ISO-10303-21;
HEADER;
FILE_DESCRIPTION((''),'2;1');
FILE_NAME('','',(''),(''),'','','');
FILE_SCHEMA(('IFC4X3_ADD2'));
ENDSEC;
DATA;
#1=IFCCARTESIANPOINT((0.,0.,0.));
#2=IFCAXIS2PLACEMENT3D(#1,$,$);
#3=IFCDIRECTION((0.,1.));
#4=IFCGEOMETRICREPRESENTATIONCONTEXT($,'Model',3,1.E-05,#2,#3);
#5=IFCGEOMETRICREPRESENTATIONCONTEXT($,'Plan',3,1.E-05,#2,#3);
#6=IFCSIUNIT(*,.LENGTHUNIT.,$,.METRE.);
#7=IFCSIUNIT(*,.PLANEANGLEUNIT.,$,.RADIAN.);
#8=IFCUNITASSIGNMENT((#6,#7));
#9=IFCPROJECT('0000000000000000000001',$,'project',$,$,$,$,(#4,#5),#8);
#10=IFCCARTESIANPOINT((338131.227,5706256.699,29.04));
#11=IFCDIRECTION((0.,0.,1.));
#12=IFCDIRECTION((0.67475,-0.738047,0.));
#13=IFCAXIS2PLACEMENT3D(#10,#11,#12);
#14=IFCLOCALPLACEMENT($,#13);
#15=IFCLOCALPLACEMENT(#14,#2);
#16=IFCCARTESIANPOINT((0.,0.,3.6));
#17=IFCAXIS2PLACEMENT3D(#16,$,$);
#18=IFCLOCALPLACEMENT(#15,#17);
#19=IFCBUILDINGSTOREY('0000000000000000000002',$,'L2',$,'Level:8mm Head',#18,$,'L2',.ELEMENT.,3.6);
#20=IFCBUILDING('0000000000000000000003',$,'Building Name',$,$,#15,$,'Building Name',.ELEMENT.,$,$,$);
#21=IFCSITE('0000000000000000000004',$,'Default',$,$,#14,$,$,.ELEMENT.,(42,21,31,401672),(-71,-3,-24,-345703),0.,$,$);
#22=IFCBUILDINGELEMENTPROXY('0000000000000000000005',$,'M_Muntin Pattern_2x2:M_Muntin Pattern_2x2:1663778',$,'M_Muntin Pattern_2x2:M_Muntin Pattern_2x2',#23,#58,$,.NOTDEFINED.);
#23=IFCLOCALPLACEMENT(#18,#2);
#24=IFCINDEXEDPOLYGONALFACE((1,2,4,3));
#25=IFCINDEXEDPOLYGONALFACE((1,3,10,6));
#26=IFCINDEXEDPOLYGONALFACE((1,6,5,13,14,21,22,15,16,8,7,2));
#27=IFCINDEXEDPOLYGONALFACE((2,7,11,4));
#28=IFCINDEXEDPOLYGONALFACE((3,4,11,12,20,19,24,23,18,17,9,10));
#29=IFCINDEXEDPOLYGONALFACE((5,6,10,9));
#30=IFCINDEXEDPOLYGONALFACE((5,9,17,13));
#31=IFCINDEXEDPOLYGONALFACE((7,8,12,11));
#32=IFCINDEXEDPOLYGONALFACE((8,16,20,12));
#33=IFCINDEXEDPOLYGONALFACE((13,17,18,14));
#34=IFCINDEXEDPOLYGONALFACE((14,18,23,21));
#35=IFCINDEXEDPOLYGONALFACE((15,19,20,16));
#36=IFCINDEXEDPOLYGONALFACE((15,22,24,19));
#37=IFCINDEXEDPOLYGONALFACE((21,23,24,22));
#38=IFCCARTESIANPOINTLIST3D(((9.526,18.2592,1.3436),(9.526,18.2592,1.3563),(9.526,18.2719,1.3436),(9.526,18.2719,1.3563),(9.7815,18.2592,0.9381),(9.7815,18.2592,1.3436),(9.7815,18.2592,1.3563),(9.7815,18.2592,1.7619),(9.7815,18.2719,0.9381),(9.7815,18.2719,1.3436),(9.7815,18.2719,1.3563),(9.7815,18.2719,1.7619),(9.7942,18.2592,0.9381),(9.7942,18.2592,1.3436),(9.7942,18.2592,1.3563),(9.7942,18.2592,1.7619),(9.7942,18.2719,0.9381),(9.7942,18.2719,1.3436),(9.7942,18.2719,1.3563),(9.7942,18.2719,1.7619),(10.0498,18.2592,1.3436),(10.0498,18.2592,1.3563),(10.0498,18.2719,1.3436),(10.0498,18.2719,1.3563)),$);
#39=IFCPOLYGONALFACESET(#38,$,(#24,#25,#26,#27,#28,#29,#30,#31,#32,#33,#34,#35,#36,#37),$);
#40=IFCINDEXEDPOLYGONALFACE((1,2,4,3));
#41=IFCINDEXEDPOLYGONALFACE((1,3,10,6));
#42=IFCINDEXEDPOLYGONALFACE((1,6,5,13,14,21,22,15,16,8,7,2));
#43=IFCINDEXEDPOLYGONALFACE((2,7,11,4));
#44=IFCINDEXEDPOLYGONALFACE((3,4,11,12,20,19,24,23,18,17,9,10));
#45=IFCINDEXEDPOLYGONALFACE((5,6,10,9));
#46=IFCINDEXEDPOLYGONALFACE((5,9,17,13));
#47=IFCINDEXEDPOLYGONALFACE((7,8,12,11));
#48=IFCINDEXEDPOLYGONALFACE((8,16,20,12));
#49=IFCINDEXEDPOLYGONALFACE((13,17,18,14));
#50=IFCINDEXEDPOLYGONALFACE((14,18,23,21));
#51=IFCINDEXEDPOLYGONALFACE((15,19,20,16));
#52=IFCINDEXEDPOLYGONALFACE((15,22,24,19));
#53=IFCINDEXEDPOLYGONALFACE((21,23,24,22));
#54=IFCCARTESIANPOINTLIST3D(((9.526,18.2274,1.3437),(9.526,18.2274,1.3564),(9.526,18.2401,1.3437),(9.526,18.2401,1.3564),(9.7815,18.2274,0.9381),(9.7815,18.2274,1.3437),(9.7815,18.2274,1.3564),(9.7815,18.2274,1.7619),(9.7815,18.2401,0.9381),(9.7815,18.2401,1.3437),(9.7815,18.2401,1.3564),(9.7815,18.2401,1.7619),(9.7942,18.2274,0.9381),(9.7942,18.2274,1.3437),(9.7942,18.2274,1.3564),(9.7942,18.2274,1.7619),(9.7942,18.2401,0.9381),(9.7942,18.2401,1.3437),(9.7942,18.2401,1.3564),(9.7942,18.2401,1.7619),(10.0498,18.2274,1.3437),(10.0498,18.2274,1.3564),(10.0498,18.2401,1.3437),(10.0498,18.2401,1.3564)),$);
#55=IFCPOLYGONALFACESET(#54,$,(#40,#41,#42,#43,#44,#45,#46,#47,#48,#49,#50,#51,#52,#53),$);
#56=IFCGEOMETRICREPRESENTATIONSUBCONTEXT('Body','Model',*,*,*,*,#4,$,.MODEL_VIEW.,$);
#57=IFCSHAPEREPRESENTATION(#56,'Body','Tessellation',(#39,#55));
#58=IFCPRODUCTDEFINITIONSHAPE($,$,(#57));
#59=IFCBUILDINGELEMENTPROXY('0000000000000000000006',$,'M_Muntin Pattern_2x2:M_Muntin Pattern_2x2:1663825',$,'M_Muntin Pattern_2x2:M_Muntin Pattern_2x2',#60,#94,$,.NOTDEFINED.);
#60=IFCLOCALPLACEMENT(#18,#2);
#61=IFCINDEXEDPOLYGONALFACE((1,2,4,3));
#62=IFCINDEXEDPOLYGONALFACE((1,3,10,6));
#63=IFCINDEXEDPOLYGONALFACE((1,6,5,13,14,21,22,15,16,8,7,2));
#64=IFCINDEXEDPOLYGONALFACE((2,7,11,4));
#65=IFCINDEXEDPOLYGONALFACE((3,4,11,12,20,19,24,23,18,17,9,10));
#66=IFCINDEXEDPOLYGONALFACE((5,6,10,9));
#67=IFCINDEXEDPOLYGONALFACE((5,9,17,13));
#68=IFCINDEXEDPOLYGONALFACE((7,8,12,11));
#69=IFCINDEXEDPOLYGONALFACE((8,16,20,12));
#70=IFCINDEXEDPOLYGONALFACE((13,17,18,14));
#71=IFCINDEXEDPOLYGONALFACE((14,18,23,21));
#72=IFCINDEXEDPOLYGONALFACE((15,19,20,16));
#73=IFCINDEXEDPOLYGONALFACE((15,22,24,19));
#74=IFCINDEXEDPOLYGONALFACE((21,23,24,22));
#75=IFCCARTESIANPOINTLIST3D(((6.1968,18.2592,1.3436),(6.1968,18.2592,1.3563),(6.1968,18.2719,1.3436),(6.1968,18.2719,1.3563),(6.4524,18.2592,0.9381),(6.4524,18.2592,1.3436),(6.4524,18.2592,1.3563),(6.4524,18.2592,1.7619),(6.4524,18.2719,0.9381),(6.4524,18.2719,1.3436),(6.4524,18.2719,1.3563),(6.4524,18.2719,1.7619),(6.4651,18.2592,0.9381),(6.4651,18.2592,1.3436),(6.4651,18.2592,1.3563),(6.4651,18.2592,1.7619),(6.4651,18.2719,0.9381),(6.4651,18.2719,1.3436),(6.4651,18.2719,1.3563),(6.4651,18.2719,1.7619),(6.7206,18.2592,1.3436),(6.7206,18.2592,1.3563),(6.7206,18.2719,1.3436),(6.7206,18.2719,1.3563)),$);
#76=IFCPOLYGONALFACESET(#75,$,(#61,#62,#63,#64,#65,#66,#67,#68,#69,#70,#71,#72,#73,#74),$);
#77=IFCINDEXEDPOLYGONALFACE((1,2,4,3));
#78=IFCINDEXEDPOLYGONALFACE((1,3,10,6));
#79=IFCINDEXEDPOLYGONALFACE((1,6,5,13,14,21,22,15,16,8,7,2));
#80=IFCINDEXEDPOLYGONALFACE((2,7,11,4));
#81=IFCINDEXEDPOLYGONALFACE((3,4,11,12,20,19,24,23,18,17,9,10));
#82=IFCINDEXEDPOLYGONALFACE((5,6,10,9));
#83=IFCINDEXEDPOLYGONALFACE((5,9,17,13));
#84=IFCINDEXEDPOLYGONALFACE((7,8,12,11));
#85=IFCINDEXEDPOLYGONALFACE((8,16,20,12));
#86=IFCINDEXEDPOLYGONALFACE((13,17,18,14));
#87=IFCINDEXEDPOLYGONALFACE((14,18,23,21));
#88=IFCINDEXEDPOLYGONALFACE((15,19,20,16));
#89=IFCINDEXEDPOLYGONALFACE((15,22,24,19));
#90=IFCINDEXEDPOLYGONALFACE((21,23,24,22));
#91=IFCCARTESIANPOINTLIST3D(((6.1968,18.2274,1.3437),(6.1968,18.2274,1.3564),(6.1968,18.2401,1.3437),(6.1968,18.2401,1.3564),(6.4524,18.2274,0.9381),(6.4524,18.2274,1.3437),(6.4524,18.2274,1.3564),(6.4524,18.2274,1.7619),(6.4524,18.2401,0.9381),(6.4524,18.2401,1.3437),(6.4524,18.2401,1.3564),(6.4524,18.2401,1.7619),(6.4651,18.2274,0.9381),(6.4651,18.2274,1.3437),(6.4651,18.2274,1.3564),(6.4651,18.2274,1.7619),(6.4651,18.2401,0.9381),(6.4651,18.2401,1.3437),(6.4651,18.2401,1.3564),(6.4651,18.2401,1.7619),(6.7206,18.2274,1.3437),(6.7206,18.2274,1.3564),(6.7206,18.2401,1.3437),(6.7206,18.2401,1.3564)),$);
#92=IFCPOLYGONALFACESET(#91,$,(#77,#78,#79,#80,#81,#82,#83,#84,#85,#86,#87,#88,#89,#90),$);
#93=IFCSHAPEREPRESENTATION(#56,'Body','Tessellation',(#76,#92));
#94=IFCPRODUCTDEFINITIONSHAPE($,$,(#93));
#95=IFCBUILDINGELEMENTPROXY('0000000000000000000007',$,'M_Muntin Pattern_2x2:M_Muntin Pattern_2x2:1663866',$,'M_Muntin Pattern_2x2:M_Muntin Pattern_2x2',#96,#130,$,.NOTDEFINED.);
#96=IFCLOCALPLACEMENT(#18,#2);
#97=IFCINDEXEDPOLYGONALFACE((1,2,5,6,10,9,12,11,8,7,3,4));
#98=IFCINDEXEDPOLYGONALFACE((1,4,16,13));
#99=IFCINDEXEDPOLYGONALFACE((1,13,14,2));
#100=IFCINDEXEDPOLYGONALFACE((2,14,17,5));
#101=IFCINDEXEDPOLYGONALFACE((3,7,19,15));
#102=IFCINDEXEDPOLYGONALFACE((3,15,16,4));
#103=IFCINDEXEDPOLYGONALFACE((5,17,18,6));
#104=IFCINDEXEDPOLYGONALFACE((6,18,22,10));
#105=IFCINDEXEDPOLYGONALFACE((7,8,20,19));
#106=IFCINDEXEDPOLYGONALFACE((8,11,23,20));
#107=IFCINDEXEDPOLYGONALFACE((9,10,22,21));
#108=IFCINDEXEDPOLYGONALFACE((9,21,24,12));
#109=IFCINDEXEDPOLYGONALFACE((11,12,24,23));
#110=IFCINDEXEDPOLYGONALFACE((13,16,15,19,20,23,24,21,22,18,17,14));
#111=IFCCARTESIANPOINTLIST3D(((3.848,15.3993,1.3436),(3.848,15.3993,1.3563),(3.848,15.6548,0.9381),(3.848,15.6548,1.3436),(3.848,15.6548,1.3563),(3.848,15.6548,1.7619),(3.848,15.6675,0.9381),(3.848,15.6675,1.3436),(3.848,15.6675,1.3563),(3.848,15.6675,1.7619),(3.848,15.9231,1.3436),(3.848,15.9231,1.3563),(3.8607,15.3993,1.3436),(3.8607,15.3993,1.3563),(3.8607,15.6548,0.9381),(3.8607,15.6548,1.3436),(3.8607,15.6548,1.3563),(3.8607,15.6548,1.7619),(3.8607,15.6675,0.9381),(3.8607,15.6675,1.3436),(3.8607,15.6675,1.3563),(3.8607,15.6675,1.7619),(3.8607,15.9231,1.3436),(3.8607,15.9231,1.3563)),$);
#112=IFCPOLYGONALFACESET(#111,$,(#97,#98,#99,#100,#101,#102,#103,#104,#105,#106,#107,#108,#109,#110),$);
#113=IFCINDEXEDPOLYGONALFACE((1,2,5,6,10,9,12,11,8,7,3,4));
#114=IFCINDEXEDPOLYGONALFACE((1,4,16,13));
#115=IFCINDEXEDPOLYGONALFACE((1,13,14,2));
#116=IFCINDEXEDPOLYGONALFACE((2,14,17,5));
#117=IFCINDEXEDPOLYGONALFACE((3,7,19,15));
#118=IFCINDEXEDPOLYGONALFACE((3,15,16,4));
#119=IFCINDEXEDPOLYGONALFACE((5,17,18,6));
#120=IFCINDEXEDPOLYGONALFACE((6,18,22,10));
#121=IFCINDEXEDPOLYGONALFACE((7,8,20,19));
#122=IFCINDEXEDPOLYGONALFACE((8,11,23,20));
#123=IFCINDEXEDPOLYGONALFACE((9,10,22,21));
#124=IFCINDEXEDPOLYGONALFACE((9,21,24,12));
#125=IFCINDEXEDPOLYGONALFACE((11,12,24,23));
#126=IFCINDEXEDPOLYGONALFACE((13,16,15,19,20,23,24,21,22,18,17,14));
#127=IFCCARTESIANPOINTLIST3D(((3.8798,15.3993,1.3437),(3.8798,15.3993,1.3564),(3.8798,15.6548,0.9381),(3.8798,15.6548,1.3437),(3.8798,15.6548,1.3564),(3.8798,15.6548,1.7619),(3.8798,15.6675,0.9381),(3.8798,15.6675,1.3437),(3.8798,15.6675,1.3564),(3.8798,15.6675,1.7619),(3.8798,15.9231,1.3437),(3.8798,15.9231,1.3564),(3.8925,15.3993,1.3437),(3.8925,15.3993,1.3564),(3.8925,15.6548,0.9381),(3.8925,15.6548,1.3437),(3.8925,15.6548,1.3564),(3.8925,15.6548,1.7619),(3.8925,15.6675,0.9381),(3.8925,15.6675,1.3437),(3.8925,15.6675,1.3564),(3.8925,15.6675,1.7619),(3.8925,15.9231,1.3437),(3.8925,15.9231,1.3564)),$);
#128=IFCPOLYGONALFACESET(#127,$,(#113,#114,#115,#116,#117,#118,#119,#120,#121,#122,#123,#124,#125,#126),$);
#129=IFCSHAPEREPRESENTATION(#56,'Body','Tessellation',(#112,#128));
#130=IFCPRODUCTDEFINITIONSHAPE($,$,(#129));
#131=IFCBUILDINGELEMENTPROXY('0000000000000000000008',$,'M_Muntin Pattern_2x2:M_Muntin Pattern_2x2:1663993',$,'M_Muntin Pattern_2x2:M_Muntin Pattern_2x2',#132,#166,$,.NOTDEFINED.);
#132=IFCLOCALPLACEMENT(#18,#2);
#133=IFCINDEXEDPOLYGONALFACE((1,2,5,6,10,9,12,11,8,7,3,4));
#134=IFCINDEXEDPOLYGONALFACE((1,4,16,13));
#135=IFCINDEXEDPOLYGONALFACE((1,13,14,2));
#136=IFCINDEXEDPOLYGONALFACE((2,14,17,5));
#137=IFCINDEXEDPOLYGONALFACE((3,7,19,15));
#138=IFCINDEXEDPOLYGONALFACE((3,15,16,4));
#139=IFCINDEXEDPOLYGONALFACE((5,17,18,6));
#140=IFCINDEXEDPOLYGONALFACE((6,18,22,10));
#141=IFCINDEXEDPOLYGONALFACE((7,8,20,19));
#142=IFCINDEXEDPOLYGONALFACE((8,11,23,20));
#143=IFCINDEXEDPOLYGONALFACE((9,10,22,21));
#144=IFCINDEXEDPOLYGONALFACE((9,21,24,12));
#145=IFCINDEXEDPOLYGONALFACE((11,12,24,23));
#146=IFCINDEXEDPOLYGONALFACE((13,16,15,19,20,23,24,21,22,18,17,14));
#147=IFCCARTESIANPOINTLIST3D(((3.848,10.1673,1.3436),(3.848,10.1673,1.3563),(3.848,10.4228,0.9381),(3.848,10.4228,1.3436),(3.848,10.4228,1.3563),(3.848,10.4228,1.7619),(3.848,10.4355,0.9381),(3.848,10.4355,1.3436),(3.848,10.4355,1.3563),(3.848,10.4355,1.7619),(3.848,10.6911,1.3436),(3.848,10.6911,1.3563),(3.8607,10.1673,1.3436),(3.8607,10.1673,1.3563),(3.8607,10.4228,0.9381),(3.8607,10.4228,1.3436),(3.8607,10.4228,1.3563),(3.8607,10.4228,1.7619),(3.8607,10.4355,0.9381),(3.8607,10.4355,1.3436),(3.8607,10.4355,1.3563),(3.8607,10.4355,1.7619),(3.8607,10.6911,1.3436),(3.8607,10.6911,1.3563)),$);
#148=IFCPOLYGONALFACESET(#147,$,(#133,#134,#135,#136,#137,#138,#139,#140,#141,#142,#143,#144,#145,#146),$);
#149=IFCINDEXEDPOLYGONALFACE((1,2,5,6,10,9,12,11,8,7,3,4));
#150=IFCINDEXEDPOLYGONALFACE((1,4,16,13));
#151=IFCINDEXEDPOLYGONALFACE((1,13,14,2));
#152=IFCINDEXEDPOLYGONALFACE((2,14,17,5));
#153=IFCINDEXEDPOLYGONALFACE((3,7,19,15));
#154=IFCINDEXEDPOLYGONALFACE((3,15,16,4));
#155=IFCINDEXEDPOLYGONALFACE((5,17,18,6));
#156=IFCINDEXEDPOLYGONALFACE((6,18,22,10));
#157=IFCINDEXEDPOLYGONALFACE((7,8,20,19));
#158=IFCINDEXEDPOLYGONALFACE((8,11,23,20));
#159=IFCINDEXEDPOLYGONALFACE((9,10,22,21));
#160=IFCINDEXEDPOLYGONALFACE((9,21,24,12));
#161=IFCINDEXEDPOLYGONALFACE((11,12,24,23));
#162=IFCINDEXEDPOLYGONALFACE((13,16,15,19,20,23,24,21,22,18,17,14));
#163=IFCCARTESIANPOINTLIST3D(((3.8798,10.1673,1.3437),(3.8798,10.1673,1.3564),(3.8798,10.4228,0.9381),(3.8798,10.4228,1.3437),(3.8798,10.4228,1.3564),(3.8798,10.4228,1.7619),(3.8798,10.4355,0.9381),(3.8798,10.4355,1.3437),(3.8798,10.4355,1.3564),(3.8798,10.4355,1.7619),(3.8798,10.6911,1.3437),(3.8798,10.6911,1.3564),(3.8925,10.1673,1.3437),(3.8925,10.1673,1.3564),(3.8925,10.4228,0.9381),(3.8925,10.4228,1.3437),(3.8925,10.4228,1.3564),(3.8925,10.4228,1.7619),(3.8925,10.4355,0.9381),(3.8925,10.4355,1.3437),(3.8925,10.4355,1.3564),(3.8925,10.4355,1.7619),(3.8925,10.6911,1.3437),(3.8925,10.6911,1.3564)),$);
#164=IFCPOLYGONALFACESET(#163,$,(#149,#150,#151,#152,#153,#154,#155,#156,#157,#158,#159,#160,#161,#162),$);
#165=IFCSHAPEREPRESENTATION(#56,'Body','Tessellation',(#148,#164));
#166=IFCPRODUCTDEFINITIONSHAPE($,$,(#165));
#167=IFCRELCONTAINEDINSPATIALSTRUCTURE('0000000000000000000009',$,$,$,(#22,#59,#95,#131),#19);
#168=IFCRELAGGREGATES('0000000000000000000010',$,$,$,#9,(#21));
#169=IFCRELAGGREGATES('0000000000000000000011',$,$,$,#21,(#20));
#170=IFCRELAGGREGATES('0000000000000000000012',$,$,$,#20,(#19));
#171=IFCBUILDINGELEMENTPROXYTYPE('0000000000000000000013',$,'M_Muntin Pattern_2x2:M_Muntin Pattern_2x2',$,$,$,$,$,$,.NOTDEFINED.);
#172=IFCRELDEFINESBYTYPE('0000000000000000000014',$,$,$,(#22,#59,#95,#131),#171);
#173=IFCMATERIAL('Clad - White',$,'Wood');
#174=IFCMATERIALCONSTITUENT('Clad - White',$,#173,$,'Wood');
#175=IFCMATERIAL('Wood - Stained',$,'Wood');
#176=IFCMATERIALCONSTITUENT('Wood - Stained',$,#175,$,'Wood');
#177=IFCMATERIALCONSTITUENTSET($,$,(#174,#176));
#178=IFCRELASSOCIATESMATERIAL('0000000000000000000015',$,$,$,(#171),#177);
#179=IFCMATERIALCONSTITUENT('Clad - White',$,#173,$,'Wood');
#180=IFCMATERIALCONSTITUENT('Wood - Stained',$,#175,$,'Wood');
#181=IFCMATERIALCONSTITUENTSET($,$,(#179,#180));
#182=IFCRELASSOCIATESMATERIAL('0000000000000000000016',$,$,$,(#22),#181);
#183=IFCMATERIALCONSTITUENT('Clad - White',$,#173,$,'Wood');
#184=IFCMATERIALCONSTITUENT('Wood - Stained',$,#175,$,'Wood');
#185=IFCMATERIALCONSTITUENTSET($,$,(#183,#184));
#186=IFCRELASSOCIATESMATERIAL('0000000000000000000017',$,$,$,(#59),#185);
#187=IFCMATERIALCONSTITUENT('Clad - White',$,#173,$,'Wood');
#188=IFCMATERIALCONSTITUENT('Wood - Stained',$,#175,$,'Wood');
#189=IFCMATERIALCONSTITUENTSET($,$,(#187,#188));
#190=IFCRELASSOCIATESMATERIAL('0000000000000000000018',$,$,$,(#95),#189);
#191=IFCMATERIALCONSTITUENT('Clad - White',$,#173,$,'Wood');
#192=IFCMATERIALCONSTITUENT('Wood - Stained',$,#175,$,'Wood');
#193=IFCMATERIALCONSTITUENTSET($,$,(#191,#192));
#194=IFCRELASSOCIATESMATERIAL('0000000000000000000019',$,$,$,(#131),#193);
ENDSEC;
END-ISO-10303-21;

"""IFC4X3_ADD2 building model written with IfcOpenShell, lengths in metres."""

from ifc_helpers import new_model, si_unit, direction, frame, origin, place, context, subcontext, project, spatial, polyline, outline, extrude, source, transform, mapped, material, constituent, constituent_set, type_object, type_shapes, element, save


model = new_model("IFC4X3_ADD2")

# Units and contexts
model_context = context("Model", 3, precision=1e-05, world=origin(), true_north=direction((0.0, 1.0)))
plan_context = context("Plan", 3, precision=1e-05, world=origin(), true_north=direction((0.0, 1.0)))
body_context = subcontext(model_context, "Body", "Model", "MODEL_VIEW")
ifc_project = project(units=[si_unit("LENGTHUNIT", "METRE"), si_unit("PLANEANGLEUNIT", "RADIAN")], contexts=[model_context, plan_context])

# Site, building, storey
site_placement = place(None, frame((338131.227, 5706256.699, 29.04), z_axis=(0.0, 0.0, 1.0), x_axis=(0.67475, -0.738047, 0.0)))
site = spatial("IfcSite", under=ifc_project, at=site_placement, Name="Default", CompositionType="ELEMENT", RefLatitude=(42, 21, 31, 401672), RefLongitude=(-71, -3, -24, -345703), RefElevation=0.0)
building_placement = place(site_placement, origin())
building = spatial("IfcBuilding", under=site, at=building_placement, Name="Building Name", LongName="Building Name", CompositionType="ELEMENT")
storey_placement = place(building_placement, frame((0.0, 0.0, 3.6)))
storey = spatial("IfcBuildingStorey", under=building, at=storey_placement, Name="L2", ObjectType="Level:8mm Head", LongName="L2", CompositionType="ELEMENT", Elevation=3.6)

# Building element proxies
ifc_material_1 = material(Name="Clad - White", Category="Wood")
ifc_constituent_1 = constituent(ifc_material_1, Name="Clad - White", Category="Wood")
ifc_material_2 = material(Name="Wood - Stained", Category="Wood")
ifc_constituent_2 = constituent(ifc_material_2, Name="Wood - Stained", Category="Wood")
ifc_constituent_set_1 = constituent_set(constituents=[ifc_constituent_1, ifc_constituent_2])
ifc_constituent_3 = constituent(ifc_material_1, Name="Clad - White", Category="Wood")
ifc_constituent_4 = constituent(ifc_material_2, Name="Wood - Stained", Category="Wood")
ifc_constituent_set_2 = constituent_set(constituents=[ifc_constituent_3, ifc_constituent_4])
building_element_proxy_type = type_object("IfcBuildingElementProxyType", Name="M_Muntin Pattern_2x2:M_Muntin Pattern_2x2", PredefinedType="NOTDEFINED", material=ifc_constituent_set_2)
shared_shape = source(origin(), body_context, "Body", "SweptSolid", [
    extrude(outline(polyline([(0.0064, -0.0064), (0.4119, -0.0064), (0.4119, 0.0063), (0.0064, 0.0063), (0.0064, 0.2619), (-0.0063, 0.2619), (-0.0063, 0.0063), (-0.4119, 0.0063), (-0.4119, -0.0064), (-0.0063, -0.0064), (-0.0063, -0.2619), (0.0064, -0.2619), (0.0064, -0.0064)])), frame((0.0, -0.0222, 0.4119), z_axis=(0.0, 1.0, 0.0), x_axis=(0.0, 0.0, 1.0)), (0.0, 0.0, 1.0), 0.0127),
    extrude(outline(polyline([(0.0064, -0.0064), (0.4119, -0.0064), (0.4119, 0.0063), (0.0064, 0.0063), (0.0064, 0.2619), (-0.0063, 0.2619), (-0.0063, 0.0063), (-0.4119, 0.0063), (-0.4119, -0.0064), (-0.0063, -0.0064), (-0.0063, -0.2619), (0.0064, -0.2619), (0.0064, -0.0064)])), frame((0.0, 0.0095, 0.4119), z_axis=(0.0, 1.0, 0.0), x_axis=(0.0, 0.0, 1.0)), (0.0, 0.0, 1.0), 0.0127),
])
type_shapes(building_element_proxy_type, [shared_shape])
proxy_1_placement = place(storey_placement, frame((9.7879, 18.2497, 0.9381), z_axis=(0.0, 0.0, 1.0), x_axis=(-1.0, 0.0, 0.0)))
element("IfcBuildingElementProxy", 1, at=proxy_1_placement, inside=storey, type_object=building_element_proxy_type, material=ifc_constituent_set_1, Name="M_Muntin Pattern_2x2:M_Muntin Pattern_2x2:1663778", ObjectType="M_Muntin Pattern_2x2:M_Muntin Pattern_2x2", PredefinedType="NOTDEFINED", context=body_context, shape_type="MappedRepresentation", body=[
    mapped(shared_shape, transform((0.0, 0.0, 0.0), scale=1.0)),
])
ifc_constituent_5 = constituent(ifc_material_1, Name="Clad - White", Category="Wood")
ifc_constituent_6 = constituent(ifc_material_2, Name="Wood - Stained", Category="Wood")
ifc_constituent_set_3 = constituent_set(constituents=[ifc_constituent_5, ifc_constituent_6])
proxy_2_placement = place(storey_placement, frame((6.4587, 18.2497, 0.9381), z_axis=(0.0, 0.0, 1.0), x_axis=(-1.0, 0.0, 0.0)))
element("IfcBuildingElementProxy", 2, at=proxy_2_placement, inside=storey, type_object=building_element_proxy_type, material=ifc_constituent_set_3, Name="M_Muntin Pattern_2x2:M_Muntin Pattern_2x2:1663825", ObjectType="M_Muntin Pattern_2x2:M_Muntin Pattern_2x2", PredefinedType="NOTDEFINED", context=body_context, shape_type="MappedRepresentation", body=[
    mapped(shared_shape, transform((0.0, 0.0, 0.0), scale=1.0)),
])
ifc_constituent_7 = constituent(ifc_material_1, Name="Clad - White", Category="Wood")
ifc_constituent_8 = constituent(ifc_material_2, Name="Wood - Stained", Category="Wood")
ifc_constituent_set_4 = constituent_set(constituents=[ifc_constituent_7, ifc_constituent_8])
proxy_3_placement = place(storey_placement, frame((3.8703, 15.6612, 0.9381), z_axis=(0.0, 0.0, 1.0), x_axis=(0.0, -1.0, 0.0)))
element("IfcBuildingElementProxy", 3, at=proxy_3_placement, inside=storey, type_object=building_element_proxy_type, material=ifc_constituent_set_4, Name="M_Muntin Pattern_2x2:M_Muntin Pattern_2x2:1663866", ObjectType="M_Muntin Pattern_2x2:M_Muntin Pattern_2x2", PredefinedType="NOTDEFINED", context=body_context, shape_type="MappedRepresentation", body=[
    mapped(shared_shape, transform((0.0, 0.0, 0.0), scale=1.0)),
])
ifc_constituent_9 = constituent(ifc_material_1, Name="Clad - White", Category="Wood")
ifc_constituent_10 = constituent(ifc_material_2, Name="Wood - Stained", Category="Wood")
ifc_constituent_set_5 = constituent_set(constituents=[ifc_constituent_9, ifc_constituent_10])
proxy_4_placement = place(storey_placement, frame((3.8703, 10.4292, 0.9381), z_axis=(0.0, 0.0, 1.0), x_axis=(0.0, -1.0, 0.0)))
element("IfcBuildingElementProxy", 4, at=proxy_4_placement, inside=storey, type_object=building_element_proxy_type, material=ifc_constituent_set_5, Name="M_Muntin Pattern_2x2:M_Muntin Pattern_2x2:1663993", ObjectType="M_Muntin Pattern_2x2:M_Muntin Pattern_2x2", PredefinedType="NOTDEFINED", context=body_context, shape_type="MappedRepresentation", body=[
    mapped(shared_shape, transform((0.0, 0.0, 0.0), scale=1.0)),
])

save(model, "model.ifc")
